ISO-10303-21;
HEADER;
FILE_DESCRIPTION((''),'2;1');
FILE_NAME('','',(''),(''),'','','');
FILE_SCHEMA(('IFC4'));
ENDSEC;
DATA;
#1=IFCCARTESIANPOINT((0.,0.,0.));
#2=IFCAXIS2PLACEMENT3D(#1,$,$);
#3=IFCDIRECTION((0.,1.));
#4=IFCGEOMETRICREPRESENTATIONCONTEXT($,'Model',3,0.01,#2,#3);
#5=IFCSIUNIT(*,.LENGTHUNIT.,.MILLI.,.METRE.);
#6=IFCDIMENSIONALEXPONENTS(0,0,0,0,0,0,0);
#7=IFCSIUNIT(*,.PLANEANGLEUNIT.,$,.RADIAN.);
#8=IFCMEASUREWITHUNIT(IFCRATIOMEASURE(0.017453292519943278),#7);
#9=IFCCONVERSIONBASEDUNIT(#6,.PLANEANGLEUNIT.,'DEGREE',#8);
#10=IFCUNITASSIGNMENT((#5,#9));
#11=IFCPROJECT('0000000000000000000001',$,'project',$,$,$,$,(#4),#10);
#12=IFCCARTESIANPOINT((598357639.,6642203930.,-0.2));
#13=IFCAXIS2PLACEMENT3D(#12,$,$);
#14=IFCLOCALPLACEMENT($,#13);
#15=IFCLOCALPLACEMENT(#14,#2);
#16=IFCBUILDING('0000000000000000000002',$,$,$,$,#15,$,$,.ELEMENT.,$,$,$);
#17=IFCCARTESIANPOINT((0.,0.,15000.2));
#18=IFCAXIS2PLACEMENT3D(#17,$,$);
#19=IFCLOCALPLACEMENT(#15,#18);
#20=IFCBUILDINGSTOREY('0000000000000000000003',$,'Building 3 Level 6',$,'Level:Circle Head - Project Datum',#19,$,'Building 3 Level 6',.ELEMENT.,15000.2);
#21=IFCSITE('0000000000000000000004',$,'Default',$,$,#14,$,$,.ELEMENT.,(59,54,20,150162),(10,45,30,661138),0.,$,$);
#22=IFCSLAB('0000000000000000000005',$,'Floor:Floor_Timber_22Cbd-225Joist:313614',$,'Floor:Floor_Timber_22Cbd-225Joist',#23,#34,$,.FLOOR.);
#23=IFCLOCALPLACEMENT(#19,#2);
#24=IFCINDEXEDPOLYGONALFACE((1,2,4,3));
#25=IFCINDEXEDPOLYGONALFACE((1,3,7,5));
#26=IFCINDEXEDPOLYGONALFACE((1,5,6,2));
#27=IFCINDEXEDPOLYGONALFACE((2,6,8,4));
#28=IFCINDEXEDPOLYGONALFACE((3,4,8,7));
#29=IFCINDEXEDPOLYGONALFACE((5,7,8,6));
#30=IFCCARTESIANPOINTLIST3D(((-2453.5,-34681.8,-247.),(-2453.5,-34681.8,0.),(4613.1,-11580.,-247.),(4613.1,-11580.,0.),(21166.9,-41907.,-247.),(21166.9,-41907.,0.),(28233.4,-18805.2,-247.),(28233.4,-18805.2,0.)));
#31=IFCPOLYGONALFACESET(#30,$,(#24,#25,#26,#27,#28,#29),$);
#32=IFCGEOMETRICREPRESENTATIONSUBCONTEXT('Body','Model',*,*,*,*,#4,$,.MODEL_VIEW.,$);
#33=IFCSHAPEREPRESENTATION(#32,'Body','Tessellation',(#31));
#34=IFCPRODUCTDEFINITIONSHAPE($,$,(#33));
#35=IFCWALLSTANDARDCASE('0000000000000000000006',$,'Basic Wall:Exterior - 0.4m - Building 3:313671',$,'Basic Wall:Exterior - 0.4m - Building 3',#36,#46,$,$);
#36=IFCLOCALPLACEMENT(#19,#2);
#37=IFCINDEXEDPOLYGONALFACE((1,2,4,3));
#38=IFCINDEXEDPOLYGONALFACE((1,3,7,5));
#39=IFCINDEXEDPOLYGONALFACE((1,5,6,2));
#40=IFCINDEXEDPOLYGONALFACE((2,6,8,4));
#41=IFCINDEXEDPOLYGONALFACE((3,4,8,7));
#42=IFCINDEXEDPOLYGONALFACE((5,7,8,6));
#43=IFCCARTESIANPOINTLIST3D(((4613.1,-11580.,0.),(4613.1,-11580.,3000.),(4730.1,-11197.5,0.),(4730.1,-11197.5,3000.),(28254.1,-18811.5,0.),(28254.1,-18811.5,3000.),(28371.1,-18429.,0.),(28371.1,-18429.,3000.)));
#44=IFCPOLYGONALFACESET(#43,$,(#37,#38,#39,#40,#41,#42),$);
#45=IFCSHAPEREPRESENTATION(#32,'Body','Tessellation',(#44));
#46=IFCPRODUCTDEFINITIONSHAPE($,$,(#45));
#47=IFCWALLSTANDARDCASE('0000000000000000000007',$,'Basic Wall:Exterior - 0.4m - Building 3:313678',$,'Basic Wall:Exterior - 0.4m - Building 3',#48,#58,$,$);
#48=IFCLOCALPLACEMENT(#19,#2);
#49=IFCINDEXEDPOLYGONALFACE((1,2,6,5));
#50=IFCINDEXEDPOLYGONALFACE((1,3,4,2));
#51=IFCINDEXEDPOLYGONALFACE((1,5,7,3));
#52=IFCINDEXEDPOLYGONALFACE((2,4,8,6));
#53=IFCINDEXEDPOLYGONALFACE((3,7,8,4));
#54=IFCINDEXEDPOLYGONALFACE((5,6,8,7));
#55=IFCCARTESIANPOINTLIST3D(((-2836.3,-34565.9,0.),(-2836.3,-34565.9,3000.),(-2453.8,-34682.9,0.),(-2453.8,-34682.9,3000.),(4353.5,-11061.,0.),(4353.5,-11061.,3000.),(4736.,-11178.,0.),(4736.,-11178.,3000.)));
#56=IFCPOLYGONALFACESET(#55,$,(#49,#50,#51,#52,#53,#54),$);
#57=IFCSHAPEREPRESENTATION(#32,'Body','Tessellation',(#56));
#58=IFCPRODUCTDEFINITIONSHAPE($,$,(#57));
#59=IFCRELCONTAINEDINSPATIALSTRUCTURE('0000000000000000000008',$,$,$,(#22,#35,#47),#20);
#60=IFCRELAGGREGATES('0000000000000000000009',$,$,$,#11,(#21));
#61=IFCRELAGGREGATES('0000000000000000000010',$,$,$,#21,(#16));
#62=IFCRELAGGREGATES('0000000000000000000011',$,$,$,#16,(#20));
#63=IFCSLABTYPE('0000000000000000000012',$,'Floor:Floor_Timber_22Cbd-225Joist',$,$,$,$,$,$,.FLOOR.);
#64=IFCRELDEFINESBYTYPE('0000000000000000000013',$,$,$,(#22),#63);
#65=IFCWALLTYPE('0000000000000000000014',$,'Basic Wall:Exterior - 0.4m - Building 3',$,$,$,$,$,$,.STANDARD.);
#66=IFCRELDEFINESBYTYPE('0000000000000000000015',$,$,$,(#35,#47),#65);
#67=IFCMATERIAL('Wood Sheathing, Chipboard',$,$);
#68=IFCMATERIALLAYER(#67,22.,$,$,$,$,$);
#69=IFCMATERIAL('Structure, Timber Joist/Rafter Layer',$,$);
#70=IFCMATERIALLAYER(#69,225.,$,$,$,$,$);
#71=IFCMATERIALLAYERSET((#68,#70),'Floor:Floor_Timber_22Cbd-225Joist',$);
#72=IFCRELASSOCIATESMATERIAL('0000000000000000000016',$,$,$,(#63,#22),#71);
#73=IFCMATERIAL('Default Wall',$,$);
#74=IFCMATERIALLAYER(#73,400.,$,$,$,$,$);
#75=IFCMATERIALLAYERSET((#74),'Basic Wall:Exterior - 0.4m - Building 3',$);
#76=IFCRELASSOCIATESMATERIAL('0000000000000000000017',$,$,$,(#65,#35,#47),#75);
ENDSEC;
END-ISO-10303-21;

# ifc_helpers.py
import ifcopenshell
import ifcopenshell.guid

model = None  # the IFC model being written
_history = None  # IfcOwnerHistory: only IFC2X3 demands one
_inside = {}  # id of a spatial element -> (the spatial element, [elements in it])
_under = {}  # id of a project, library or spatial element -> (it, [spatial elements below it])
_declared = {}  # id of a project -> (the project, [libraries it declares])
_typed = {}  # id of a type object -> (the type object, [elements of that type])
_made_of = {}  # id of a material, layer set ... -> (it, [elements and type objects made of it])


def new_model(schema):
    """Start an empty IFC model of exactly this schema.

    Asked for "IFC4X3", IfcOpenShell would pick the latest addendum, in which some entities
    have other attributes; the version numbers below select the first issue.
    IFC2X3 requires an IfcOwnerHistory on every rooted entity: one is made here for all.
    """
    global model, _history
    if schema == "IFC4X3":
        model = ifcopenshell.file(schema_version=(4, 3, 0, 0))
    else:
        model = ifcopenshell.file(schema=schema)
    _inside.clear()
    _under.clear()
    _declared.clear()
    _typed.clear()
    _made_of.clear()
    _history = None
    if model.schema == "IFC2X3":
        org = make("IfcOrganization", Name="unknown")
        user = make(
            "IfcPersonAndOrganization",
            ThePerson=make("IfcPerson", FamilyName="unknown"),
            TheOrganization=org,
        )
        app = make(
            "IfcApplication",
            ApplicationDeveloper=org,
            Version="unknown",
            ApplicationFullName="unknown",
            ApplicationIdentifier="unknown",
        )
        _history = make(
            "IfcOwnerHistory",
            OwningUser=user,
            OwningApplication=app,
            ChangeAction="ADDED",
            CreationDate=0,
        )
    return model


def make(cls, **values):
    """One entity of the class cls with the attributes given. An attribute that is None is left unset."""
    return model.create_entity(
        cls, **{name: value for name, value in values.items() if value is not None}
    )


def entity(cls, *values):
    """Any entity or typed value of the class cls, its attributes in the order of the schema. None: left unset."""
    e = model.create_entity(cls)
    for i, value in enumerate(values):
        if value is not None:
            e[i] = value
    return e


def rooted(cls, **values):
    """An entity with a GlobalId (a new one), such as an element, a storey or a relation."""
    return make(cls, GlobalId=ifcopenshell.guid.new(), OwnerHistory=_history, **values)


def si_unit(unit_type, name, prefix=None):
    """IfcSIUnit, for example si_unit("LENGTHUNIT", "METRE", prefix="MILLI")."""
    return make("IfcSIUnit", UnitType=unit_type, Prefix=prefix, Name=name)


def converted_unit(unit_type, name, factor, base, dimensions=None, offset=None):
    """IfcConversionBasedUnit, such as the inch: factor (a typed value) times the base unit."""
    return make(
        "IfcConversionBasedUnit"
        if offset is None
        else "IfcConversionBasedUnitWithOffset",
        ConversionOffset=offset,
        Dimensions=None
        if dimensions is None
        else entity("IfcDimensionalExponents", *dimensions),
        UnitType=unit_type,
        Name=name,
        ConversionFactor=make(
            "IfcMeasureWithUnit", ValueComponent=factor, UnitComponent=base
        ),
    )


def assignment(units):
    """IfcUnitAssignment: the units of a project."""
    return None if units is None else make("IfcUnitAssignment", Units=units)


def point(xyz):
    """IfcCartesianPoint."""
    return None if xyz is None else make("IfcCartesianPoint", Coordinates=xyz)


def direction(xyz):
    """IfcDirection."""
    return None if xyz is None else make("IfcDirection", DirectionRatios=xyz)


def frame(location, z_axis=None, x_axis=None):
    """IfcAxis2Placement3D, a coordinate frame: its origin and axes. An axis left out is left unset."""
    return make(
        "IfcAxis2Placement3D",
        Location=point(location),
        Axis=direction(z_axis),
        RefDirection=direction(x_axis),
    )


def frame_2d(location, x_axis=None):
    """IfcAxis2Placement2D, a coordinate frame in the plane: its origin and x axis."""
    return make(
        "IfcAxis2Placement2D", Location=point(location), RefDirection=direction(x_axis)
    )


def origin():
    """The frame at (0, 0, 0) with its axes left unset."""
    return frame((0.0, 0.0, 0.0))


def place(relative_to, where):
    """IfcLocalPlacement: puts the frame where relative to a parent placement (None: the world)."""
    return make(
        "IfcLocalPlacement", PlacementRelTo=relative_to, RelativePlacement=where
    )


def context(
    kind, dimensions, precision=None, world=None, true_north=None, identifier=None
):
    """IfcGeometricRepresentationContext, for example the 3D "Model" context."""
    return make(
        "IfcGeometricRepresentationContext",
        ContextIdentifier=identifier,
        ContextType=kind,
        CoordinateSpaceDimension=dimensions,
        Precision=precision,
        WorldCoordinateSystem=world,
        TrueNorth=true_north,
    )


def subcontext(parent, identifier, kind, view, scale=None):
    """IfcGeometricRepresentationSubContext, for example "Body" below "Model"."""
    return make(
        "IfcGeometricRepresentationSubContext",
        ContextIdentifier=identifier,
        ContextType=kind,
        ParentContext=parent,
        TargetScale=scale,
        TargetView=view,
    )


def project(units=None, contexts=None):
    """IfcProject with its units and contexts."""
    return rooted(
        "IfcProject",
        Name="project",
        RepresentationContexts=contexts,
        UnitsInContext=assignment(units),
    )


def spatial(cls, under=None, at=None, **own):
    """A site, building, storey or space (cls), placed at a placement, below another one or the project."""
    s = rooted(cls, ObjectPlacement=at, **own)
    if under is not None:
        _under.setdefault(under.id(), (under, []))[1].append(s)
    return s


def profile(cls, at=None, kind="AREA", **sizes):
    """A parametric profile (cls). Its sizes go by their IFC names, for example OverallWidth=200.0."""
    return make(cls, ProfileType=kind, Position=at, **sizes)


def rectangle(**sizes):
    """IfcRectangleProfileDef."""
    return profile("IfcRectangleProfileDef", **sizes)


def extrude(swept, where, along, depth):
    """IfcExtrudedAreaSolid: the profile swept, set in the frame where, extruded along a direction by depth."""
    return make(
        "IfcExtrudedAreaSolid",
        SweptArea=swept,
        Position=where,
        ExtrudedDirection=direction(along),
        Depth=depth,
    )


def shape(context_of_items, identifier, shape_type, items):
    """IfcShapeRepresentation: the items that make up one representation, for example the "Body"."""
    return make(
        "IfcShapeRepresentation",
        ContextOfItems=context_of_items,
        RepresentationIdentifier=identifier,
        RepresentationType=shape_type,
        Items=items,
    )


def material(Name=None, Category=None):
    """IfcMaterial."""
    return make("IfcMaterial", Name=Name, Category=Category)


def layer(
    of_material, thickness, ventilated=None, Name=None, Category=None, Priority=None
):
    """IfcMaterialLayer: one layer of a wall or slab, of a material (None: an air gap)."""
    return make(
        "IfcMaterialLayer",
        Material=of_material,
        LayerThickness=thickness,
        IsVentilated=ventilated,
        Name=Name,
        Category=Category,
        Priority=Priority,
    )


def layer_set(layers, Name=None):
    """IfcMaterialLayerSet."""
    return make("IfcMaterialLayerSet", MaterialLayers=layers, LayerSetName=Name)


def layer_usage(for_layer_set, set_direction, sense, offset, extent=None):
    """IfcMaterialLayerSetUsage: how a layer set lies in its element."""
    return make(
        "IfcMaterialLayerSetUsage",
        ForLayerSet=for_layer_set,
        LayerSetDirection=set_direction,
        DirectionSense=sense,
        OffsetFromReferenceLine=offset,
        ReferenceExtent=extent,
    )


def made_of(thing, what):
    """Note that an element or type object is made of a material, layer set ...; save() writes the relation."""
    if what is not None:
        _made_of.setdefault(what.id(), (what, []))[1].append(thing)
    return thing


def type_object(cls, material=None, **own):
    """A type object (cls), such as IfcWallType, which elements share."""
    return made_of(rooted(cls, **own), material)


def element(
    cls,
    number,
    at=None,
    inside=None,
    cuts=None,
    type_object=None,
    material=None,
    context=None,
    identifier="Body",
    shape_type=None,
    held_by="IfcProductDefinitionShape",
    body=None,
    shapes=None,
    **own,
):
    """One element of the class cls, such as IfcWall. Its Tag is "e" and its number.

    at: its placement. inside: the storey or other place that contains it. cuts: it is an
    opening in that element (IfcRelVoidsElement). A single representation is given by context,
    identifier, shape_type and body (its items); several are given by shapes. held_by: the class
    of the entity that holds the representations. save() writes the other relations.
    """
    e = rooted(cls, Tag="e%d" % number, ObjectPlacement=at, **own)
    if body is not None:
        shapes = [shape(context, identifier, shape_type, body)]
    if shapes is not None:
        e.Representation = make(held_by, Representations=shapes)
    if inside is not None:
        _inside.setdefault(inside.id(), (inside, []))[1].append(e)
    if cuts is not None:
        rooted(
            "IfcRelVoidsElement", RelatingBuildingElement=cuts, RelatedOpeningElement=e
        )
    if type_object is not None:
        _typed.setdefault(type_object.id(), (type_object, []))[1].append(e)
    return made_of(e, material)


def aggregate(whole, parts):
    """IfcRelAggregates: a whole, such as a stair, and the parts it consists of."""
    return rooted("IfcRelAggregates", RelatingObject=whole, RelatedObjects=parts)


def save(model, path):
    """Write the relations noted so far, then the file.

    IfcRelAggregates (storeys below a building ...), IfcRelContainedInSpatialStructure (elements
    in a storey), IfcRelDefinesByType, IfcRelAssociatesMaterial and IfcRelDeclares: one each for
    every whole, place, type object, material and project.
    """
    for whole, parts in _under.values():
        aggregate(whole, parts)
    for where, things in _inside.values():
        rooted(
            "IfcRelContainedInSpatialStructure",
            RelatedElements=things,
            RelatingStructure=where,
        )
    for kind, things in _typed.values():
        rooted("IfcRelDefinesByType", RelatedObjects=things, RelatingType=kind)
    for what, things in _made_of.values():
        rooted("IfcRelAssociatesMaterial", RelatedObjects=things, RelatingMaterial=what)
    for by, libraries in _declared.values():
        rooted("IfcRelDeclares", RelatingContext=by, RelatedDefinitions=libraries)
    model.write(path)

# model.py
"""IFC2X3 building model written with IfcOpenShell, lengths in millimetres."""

from ifc_helpers import new_model, entity, si_unit, converted_unit, direction, frame, frame_2d, origin, place, context, subcontext, project, spatial, rectangle, extrude, material, layer, layer_set, layer_usage, type_object, element, save


model = new_model("IFC2X3")

# Units and contexts
model_context = context("Model", 3, precision=0.01, world=origin(), true_north=direction((0.0, 1.0)))
body_context = subcontext(model_context, "Body", "Model", "MODEL_VIEW")
ifc_project = project(units=[si_unit("LENGTHUNIT", "METRE", prefix="MILLI"), converted_unit("PLANEANGLEUNIT", "DEGREE", entity("IfcRatioMeasure", 0.017453292519943278), si_unit("PLANEANGLEUNIT", "RADIAN"), dimensions=[0, 0, 0, 0, 0, 0, 0])], contexts=[model_context])

# Site, building, storey
site_placement = place(None, frame((598357639.0, 6642203930.0, -0.2)))
site = spatial("IfcSite", under=ifc_project, at=site_placement, Name="Default", CompositionType="ELEMENT", RefLatitude=(59, 54, 20, 150162), RefLongitude=(10, 45, 30, 661138), RefElevation=0.0)
building_placement = place(site_placement, origin())
building = spatial("IfcBuilding", under=site, at=building_placement, CompositionType="ELEMENT")
storey_placement = place(building_placement, frame((0.0, 0.0, 15000.2)))
storey = spatial("IfcBuildingStorey", under=building, at=storey_placement, Name="Building 3 Level 6", ObjectType="Level:Circle Head - Project Datum", LongName="Building 3 Level 6", CompositionType="ELEMENT", Elevation=15000.2)

# Slab
ifc_material_1 = material(Name="Wood Sheathing, Chipboard")
ifc_layer_1 = layer(ifc_material_1, 22.0)
ifc_material_2 = material(Name="Structure, Timber Joist/Rafter Layer")
ifc_layer_2 = layer(ifc_material_2, 225.0)
ifc_layer_set_1 = layer_set([ifc_layer_1, ifc_layer_2], Name="Floor:Floor_Timber_22Cbd-225Joist")
ifc_layer_usage_1 = layer_usage(ifc_layer_set_1, "AXIS3", "POSITIVE", 0.0)
slab_type = type_object("IfcSlabType", Name="Floor:Floor_Timber_22Cbd-225Joist", PredefinedType="FLOOR", material=ifc_layer_set_1)
slab_placement = place(storey_placement, origin())
element("IfcSlab", 1, at=slab_placement, inside=storey, type_object=slab_type, material=ifc_layer_usage_1, Name="Floor:Floor_Timber_22Cbd-225Joist:313614", ObjectType="Floor:Floor_Timber_22Cbd-225Joist", PredefinedType="FLOOR", context=body_context, shape_type="SweptSolid", body=[
    extrude(rectangle(XDim=24158.4, YDim=24700.7, at=frame_2d((0.0, 0.0), x_axis=(1.0, 0.0))), frame((12890.0, -26743.5, 0.0), z_axis=(0.0, 0.0, -1.0), x_axis=(-0.292509, -0.956263, 0.0)), (0.0, 0.0, 1.0), 247.0),
])

# Walls
ifc_material_3 = material(Name="Default Wall")
ifc_layer_3 = layer(ifc_material_3, 400.0)
ifc_layer_set_2 = layer_set([ifc_layer_3], Name="Basic Wall:Exterior - 0.4m - Building 3")
ifc_layer_usage_2 = layer_usage(ifc_layer_set_2, "AXIS2", "POSITIVE", -200.0)
wall_type = type_object("IfcWallType", Name="Basic Wall:Exterior - 0.4m - Building 3", PredefinedType="STANDARD", material=ifc_layer_set_2)
wall_1_placement = place(storey_placement, frame((28312.6, -18620.3, 0.0), z_axis=(0.0, 0.0, 1.0), x_axis=(-0.956263, 0.292509, 0.0)))
element("IfcWallStandardCase", 2, at=wall_1_placement, inside=storey, type_object=wall_type, material=ifc_layer_usage_2, Name="Basic Wall:Exterior - 0.4m - Building 3:313671", ObjectType="Basic Wall:Exterior - 0.4m - Building 3", context=body_context, shape_type="SweptSolid", body=[
    extrude(rectangle(XDim=24722.3, YDim=400.0, at=frame_2d((12361.2, 0.0), x_axis=(-1.0, 0.0))), origin(), (0.0, 0.0, 1.0), 3000.0),
])
wall_2_placement = place(storey_placement, frame((4544.8, -11119.5, 0.0), z_axis=(0.0, 0.0, 1.0), x_axis=(-0.292509, -0.956263, 0.0)))
element("IfcWallStandardCase", 3, at=wall_2_placement, inside=storey, type_object=wall_type, material=ifc_layer_usage_2, Name="Basic Wall:Exterior - 0.4m - Building 3:313678", ObjectType="Basic Wall:Exterior - 0.4m - Building 3", context=body_context, shape_type="SweptSolid", body=[
    extrude(rectangle(XDim=24580.0, YDim=400.0, at=frame_2d((12290.0, 0.0), x_axis=(-1.0, 0.0))), origin(), (0.0, 0.0, 1.0), 3000.0),
])

save(model, "model.ifc")
